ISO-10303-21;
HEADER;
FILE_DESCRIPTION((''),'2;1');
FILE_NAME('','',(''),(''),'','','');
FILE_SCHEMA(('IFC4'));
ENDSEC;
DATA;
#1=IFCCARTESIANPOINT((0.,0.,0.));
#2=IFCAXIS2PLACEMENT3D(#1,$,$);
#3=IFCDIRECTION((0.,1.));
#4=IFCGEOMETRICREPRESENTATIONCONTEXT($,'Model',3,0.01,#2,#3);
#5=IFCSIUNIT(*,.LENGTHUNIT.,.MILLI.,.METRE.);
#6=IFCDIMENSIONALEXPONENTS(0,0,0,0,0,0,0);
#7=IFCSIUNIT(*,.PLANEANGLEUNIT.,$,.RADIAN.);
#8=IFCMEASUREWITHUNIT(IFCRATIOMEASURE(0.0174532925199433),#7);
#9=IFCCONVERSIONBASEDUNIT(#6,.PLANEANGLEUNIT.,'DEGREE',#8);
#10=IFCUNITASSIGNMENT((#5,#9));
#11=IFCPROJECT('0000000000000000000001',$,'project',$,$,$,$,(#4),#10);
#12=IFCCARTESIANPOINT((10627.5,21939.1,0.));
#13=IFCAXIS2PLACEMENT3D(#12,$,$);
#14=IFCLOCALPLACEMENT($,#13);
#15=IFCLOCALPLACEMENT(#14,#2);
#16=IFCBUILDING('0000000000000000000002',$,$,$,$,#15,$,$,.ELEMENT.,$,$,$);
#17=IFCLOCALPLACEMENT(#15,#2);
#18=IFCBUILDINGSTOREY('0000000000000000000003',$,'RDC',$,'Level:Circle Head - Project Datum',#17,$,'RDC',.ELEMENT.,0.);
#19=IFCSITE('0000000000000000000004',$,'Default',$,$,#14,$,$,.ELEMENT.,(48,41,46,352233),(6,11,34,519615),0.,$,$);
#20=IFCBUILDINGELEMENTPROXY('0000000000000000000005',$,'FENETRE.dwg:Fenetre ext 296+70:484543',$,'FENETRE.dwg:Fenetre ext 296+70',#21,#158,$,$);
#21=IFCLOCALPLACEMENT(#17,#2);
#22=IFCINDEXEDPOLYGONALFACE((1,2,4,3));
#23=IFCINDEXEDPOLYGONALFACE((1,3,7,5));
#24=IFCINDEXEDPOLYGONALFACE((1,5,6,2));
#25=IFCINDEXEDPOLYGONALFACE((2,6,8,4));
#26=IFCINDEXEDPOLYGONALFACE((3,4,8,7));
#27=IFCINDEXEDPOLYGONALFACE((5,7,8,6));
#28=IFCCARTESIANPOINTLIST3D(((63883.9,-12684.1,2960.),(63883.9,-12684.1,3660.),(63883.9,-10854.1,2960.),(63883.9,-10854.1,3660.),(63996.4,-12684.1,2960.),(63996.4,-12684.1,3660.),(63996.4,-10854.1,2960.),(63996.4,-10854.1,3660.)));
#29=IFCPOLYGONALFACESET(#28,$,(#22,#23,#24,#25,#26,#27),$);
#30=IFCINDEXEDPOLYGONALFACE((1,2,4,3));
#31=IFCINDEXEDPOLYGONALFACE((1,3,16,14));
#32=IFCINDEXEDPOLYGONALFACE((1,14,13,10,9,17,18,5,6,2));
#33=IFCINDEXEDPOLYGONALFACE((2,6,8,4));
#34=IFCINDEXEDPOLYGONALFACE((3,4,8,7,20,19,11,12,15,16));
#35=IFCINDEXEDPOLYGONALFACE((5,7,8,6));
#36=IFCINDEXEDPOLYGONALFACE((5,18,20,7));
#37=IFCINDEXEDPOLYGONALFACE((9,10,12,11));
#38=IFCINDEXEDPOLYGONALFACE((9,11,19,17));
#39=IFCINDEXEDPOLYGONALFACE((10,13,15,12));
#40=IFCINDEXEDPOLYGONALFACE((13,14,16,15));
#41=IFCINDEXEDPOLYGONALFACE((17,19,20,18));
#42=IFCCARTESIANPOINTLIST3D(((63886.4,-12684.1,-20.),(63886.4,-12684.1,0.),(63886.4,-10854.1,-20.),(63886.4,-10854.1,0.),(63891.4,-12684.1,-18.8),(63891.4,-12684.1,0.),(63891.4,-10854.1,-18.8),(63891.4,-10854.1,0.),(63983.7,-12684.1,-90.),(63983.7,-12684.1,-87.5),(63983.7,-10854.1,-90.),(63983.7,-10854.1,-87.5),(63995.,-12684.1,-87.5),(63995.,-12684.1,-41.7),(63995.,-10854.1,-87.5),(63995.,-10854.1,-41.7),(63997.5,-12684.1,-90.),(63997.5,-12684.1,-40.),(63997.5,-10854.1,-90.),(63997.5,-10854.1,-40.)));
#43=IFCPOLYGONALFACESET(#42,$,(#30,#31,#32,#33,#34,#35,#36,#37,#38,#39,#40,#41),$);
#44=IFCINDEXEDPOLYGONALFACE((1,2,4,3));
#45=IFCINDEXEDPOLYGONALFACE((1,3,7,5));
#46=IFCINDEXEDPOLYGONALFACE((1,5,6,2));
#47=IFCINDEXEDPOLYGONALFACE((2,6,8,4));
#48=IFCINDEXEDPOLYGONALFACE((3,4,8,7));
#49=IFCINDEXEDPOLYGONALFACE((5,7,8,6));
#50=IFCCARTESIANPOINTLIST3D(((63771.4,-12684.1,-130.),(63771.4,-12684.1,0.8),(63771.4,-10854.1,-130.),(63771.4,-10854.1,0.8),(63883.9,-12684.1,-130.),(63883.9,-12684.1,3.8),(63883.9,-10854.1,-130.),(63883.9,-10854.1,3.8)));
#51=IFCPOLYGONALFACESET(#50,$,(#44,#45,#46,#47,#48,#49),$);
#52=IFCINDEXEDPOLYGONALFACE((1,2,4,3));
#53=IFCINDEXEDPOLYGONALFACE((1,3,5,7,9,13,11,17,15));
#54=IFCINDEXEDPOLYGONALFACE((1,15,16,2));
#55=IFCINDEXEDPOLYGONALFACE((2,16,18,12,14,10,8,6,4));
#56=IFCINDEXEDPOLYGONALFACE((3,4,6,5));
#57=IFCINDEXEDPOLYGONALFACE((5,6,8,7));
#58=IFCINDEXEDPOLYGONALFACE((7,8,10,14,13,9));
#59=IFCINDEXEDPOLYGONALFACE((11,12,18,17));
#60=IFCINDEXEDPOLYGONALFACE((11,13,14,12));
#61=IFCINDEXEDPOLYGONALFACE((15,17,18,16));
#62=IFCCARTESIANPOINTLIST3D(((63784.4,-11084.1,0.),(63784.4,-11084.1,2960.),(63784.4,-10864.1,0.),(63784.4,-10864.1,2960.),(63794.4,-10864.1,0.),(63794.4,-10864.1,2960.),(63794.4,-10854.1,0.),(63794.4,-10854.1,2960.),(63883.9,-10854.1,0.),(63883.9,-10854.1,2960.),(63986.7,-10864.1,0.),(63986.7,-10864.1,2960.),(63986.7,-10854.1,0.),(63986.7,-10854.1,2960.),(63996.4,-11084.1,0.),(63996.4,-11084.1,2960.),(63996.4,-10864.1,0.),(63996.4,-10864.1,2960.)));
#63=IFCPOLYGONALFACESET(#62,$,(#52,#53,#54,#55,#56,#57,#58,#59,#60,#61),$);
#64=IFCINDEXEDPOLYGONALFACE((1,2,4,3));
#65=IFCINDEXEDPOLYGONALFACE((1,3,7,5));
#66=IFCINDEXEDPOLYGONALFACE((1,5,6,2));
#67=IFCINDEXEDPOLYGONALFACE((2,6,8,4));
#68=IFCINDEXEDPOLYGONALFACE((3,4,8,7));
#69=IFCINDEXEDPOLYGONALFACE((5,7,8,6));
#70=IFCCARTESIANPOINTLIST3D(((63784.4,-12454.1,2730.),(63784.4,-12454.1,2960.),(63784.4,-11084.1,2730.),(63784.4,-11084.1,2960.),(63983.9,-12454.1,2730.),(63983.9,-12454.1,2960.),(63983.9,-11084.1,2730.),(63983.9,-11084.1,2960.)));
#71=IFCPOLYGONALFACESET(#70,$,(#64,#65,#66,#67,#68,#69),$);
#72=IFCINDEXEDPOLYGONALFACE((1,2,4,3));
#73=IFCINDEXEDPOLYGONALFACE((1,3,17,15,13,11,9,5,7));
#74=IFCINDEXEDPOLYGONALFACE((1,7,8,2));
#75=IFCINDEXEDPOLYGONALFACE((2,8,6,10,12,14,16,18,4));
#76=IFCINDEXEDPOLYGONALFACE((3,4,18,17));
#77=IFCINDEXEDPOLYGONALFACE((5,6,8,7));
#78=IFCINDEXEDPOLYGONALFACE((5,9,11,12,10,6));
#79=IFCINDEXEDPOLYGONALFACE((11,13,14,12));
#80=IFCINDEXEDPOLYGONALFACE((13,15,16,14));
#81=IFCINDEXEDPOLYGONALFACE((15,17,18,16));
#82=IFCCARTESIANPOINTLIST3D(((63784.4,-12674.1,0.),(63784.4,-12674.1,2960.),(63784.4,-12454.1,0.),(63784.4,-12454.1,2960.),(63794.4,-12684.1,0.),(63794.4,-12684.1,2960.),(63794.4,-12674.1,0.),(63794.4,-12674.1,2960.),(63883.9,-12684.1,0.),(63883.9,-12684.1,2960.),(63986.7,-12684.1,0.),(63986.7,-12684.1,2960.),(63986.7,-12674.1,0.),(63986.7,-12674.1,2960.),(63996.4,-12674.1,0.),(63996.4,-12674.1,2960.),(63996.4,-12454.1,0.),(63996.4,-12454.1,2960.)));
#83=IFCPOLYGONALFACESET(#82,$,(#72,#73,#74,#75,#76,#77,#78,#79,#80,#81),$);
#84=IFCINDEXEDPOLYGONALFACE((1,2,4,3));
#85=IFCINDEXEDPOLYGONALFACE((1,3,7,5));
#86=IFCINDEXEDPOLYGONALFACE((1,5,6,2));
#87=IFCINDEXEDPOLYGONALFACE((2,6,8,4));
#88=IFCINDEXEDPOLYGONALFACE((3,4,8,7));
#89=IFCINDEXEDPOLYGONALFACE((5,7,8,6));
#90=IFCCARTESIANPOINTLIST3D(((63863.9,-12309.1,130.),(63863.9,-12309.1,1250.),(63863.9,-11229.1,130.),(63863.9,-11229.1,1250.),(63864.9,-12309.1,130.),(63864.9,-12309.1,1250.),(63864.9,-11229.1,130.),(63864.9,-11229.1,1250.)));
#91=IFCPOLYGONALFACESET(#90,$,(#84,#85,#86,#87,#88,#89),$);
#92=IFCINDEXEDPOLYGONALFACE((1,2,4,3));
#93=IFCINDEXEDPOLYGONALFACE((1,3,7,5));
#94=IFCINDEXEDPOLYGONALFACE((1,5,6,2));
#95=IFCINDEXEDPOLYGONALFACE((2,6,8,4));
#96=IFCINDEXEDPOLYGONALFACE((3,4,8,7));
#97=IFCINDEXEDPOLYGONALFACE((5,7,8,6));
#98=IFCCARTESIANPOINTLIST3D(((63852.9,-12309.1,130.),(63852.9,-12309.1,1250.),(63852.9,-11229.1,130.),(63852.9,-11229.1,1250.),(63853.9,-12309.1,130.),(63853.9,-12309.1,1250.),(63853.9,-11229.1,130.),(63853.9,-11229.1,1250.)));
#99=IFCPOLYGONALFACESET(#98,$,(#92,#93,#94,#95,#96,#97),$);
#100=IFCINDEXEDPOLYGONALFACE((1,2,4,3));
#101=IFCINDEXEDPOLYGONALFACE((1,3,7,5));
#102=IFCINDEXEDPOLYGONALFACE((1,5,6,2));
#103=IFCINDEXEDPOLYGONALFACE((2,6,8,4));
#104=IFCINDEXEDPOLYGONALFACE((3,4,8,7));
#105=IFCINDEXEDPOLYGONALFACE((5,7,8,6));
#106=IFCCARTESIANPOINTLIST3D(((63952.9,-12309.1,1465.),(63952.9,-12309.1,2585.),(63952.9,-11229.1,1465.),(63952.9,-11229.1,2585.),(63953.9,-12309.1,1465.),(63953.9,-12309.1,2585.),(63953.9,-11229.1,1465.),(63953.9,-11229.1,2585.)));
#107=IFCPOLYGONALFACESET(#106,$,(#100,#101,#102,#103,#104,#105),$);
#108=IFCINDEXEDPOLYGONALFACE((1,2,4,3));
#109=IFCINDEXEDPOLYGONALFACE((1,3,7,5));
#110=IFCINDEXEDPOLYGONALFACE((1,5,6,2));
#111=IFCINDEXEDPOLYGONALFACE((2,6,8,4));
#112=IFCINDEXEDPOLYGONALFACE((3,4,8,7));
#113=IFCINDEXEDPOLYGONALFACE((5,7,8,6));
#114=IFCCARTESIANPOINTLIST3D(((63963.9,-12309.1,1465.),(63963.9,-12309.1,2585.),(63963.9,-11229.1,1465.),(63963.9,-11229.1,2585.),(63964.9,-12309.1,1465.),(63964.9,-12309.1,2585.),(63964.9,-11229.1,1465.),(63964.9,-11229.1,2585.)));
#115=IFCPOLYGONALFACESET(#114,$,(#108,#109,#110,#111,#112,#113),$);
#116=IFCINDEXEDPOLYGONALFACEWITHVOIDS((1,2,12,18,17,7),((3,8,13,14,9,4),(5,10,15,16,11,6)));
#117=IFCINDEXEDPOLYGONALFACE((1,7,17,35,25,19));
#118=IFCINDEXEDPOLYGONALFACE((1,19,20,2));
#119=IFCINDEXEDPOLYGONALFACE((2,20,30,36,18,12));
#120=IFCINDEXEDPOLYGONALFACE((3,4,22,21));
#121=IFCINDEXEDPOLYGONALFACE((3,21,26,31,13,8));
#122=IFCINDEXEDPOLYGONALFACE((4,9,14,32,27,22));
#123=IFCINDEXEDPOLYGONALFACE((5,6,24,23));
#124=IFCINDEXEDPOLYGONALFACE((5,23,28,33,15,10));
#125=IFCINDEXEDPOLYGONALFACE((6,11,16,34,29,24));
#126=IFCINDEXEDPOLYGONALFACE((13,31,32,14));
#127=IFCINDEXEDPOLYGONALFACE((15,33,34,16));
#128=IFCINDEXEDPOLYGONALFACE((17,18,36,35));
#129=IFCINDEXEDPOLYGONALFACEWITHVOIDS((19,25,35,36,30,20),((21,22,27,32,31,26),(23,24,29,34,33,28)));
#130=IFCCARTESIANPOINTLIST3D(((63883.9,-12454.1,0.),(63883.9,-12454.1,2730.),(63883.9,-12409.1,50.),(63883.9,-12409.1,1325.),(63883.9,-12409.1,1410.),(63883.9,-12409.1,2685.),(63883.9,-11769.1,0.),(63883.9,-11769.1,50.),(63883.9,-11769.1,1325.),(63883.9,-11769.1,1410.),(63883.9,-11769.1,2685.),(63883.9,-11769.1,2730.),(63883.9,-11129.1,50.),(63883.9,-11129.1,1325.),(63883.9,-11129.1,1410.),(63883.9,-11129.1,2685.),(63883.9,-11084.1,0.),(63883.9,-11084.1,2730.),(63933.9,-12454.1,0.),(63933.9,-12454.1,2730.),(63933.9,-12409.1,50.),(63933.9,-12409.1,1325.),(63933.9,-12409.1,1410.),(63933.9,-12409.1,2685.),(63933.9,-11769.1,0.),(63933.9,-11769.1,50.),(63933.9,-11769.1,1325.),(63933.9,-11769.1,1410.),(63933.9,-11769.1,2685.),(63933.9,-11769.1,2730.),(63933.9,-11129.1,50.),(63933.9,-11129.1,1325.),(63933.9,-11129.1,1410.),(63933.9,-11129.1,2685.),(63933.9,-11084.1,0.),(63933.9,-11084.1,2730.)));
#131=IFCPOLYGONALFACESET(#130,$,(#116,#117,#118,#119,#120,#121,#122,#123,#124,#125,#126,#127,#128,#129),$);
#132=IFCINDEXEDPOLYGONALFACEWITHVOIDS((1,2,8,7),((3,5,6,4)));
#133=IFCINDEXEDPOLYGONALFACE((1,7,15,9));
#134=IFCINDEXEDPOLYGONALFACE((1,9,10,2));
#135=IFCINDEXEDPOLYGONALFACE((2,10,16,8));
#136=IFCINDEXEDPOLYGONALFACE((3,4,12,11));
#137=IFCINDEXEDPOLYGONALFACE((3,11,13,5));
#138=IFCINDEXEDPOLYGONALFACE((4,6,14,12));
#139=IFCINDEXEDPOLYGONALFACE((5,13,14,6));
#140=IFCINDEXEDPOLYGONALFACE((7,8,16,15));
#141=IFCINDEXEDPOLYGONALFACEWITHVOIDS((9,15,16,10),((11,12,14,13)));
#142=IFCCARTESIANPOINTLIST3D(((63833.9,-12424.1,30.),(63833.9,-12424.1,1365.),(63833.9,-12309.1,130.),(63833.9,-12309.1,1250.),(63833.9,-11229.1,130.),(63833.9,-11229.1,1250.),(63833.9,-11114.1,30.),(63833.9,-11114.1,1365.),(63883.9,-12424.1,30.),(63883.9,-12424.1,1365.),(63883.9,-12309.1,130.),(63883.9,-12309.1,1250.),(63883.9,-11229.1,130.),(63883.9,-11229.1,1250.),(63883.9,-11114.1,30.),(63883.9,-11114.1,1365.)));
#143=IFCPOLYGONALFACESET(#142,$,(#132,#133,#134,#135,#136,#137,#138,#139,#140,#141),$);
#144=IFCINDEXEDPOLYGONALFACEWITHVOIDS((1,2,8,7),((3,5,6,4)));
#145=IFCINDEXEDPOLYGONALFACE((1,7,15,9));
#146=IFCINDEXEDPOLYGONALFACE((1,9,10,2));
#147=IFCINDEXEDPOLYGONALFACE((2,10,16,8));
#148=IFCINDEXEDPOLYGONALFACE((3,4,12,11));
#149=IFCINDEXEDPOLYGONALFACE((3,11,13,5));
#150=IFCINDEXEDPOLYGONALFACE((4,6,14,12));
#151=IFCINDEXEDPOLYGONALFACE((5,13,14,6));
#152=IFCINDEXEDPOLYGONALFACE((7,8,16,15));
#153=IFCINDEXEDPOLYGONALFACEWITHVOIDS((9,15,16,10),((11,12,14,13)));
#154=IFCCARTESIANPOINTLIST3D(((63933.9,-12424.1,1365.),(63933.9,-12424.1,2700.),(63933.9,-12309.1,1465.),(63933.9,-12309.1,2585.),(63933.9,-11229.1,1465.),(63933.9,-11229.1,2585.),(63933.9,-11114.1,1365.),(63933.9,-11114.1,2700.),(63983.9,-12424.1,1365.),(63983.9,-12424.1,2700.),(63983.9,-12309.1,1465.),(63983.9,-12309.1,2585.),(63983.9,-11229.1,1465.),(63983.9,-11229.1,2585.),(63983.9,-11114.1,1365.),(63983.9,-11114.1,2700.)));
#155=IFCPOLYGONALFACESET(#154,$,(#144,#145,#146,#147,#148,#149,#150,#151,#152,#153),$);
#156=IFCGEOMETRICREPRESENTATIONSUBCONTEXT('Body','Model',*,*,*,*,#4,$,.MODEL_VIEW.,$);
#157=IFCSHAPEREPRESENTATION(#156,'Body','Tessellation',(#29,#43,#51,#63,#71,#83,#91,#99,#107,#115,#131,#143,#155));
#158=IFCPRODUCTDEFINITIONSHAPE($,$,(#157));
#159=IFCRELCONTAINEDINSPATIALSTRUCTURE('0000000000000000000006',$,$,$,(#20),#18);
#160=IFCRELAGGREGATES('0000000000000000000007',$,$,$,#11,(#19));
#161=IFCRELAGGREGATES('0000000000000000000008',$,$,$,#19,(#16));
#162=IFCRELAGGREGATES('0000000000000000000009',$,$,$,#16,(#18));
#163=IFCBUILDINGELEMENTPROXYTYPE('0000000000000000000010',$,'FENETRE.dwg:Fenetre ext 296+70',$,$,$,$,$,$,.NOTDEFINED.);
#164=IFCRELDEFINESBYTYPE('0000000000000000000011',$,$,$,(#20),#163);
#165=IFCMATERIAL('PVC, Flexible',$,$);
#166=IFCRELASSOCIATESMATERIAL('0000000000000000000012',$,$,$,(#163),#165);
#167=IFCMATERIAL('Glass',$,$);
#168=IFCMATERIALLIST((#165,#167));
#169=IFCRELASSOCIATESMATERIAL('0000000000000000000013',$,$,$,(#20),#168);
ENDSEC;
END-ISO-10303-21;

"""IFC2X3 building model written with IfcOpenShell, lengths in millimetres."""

from ifc_helpers import new_model, entity, si_unit, converted_unit, direction, frame, frame_2d, origin, origin_2d_with_axis, place, context, subcontext, project, spatial, polyline, rectangle, outline, extrude, source, transform, mapped, material, material_list, type_object, type_shapes, element, save


model = new_model("IFC2X3")

# Units and contexts
model_context = context("Model", 3, precision=0.01, world=origin(), true_north=direction((0.0, 1.0)))
body_context = subcontext(model_context, "Body", "Model", "MODEL_VIEW")
ifc_project = project(units=[si_unit("LENGTHUNIT", "METRE", prefix="MILLI"), converted_unit("PLANEANGLEUNIT", "DEGREE", entity("IfcRatioMeasure", 0.0174532925199433), si_unit("PLANEANGLEUNIT", "RADIAN"), dimensions=[0, 0, 0, 0, 0, 0, 0])], contexts=[model_context])

# Site, building, storey
site_placement = place(None, frame((10627.5, 21939.1, 0.0)))
site = spatial("IfcSite", under=ifc_project, at=site_placement, Name="Default", CompositionType="ELEMENT", RefLatitude=(48, 41, 46, 352233), RefLongitude=(6, 11, 34, 519615), RefElevation=0.0)
building_placement = place(site_placement, origin())
building = spatial("IfcBuilding", under=site, at=building_placement, CompositionType="ELEMENT")
storey_placement = place(building_placement, origin())
storey = spatial("IfcBuildingStorey", under=building, at=storey_placement, Name="RDC", ObjectType="Level:Circle Head - Project Datum", LongName="RDC", CompositionType="ELEMENT", Elevation=0.0)

# Building element proxy
ifc_material_1 = material(Name="PVC, Flexible")
ifc_material_2 = material(Name="Glass")
building_element_proxy_type_1 = type_object("IfcBuildingElementProxyType", Name="FENETRE.dwg:Fenetre ext 296+70", PredefinedType="NOTDEFINED", material=ifc_material_1)
shared_shape_1 = source(origin(), body_context, "Body", "SweptSolid", [
    extrude(rectangle(XDim=112.5, YDim=1830.0, at=origin_2d_with_axis()), frame((-10.4, -56.3, 2960.0), z_axis=(0.0, 0.0, 1.0), x_axis=(0.0, 1.0, 0.0)), (0.0, 0.0, 1.0), 700.0),
    extrude(outline(polyline([(27.5, -64.4), (47.5, -64.4), (47.5, -59.4), (28.8, -59.4), (7.5, 46.7), (-42.5, 46.7), (-42.5, 32.9), (-40.0, 32.9), (-40.0, 44.2), (5.8, 44.2), (27.5, -64.4)])), frame((-925.4, -66.9, -47.5), z_axis=(1.0, 0.0, 0.0), x_axis=(0.0, 0.0, 1.0)), (0.0, 0.0, 1.0), 1830.0),
    extrude(outline(polyline([(-54.5, -66.1), (58.0, -66.1), (54.5, 67.6), (-58.0, 64.6), (-54.5, -66.1)])), frame((-925.4, 56.3, -63.8), z_axis=(1.0, 0.0, 0.0), x_axis=(0.0, -0.999645, 0.02665)), (0.0, 0.0, 1.0), 1830.0),
    extrude(outline(polyline([(-97.0, -55.6), (5.9, -55.6), (95.4, -55.6), (95.4, -45.6), (105.4, -45.6), (105.4, 174.4), (-106.6, 174.4), (-106.6, -45.6), (-97.0, -45.6), (-97.0, -55.6)])), frame((849.0, -5.9, 0.0), z_axis=(0.0, 0.0, 1.0), x_axis=(0.0, 1.0, 0.0)), (0.0, 0.0, 1.0), 2960.0),
    extrude(rectangle(XDim=1370.0, YDim=199.5, at=origin_2d_with_axis()), frame((-10.4, -0.3, 2730.0), z_axis=(0.0, 0.0, 1.0), x_axis=(-1.0, 0.0, 0.0)), (0.0, 0.0, 1.0), 230.0),
    extrude(outline(polyline([(-55.6, 97.0), (-55.6, -5.9), (-55.6, -95.4), (-45.6, -95.4), (-45.6, -105.4), (174.4, -105.4), (174.4, 106.6), (-45.6, 106.6), (-45.6, 97.0), (-55.6, 97.0)])), frame((-869.9, -5.9, 0.0), z_axis=(0.0, 0.0, -1.0), x_axis=(1.0, 0.0, 0.0)), (0.0, 0.0, -1.0), 2960.0),
    extrude(rectangle(XDim=1080.0, YDim=1.0, at=origin_2d_with_axis()), frame((-10.4, 19.5, 130.0), z_axis=(0.0, 0.0, 1.0), x_axis=(-1.0, 0.0, 0.0)), (0.0, 0.0, 1.0), 1120.0),
    extrude(rectangle(XDim=1080.0, YDim=1.0, at=origin_2d_with_axis()), frame((-10.4, 30.5, 130.0), z_axis=(0.0, 0.0, 1.0), x_axis=(-1.0, 0.0, 0.0)), (0.0, 0.0, 1.0), 1120.0),
    extrude(rectangle(XDim=1080.0, YDim=1.0, at=frame_2d((0.0, 0.0), x_axis=(1.0, 0.0))), frame((-10.4, -69.5, 1465.0), z_axis=(0.0, 0.0, 1.0), x_axis=(-1.0, 0.0, 0.0)), (0.0, 0.0, 1.0), 1120.0),
    extrude(rectangle(XDim=1080.0, YDim=1.0, at=frame_2d((0.0, 0.0), x_axis=(1.0, 0.0))), frame((-10.4, -80.5, 1465.0), z_axis=(0.0, 0.0, 1.0), x_axis=(-1.0, 0.0, 0.0)), (0.0, 0.0, 1.0), 1120.0),
    extrude(outline(polyline([(-685.0, -1365.0), (0.0, -1365.0), (685.0, -1365.0), (685.0, 1365.0), (0.0, 1365.0), (-685.0, 1365.0), (-685.0, -1365.0)]), holes=[polyline([(-640.0, -1320.0), (-640.0, -45.0), (0.0, -45.0), (640.0, -45.0), (640.0, -1320.0), (0.0, -1320.0), (-640.0, -1320.0)]), polyline([(-640.0, 40.0), (-640.0, 1315.0), (0.0, 1315.0), (640.0, 1315.0), (640.0, 40.0), (0.0, 40.0), (-640.0, 40.0)])]), frame((-10.4, -50.0, 1365.0), z_axis=(0.0, 1.0, 0.0), x_axis=(1.0, 0.0, 0.0)), (0.0, 0.0, 1.0), 50.0),
    extrude(outline(polyline([(-655.0, -667.5), (655.0, -667.5), (655.0, 667.5), (-655.0, 667.5), (-655.0, -667.5)]), holes=[polyline([(-540.0, 552.5), (540.0, 552.5), (540.0, -567.5), (-540.0, -567.5), (-540.0, 552.5)])]), frame((-10.4, 0.0, 697.5), z_axis=(0.0, 1.0, 0.0), x_axis=(-1.0, 0.0, 0.0)), (0.0, 0.0, 1.0), 50.0),
    extrude(outline(polyline([(-655.0, -667.5), (655.0, -667.5), (655.0, 667.5), (-655.0, 667.5), (-655.0, -667.5)]), holes=[polyline([(-540.0, 552.5), (540.0, 552.5), (540.0, -567.5), (-540.0, -567.5), (-540.0, 552.5)])]), frame((-10.4, -100.0, 2032.5), z_axis=(0.0, 1.0, 0.0), x_axis=(-1.0, 0.0, 0.0)), (0.0, 0.0, 1.0), 50.0),
])
type_shapes(building_element_proxy_type_1, [shared_shape_1])
ifc_material_list_1 = material_list([ifc_material_1, ifc_material_2])
proxy_1_placement = place(storey_placement, frame((63883.9, -11758.7, 0.0), z_axis=(0.0, 0.0, 1.0), x_axis=(0.0, 1.0, 0.0)))
element("IfcBuildingElementProxy", 1, at=proxy_1_placement, inside=storey, type_object=building_element_proxy_type_1, material=ifc_material_list_1, Name="FENETRE.dwg:Fenetre ext 296+70:484543", ObjectType="FENETRE.dwg:Fenetre ext 296+70", context=body_context, shape_type="MappedRepresentation", body=[
    mapped(shared_shape_1, transform((0.0, 0.0, 0.0), scale=1.0)),
])

save(model, "model.ifc")
